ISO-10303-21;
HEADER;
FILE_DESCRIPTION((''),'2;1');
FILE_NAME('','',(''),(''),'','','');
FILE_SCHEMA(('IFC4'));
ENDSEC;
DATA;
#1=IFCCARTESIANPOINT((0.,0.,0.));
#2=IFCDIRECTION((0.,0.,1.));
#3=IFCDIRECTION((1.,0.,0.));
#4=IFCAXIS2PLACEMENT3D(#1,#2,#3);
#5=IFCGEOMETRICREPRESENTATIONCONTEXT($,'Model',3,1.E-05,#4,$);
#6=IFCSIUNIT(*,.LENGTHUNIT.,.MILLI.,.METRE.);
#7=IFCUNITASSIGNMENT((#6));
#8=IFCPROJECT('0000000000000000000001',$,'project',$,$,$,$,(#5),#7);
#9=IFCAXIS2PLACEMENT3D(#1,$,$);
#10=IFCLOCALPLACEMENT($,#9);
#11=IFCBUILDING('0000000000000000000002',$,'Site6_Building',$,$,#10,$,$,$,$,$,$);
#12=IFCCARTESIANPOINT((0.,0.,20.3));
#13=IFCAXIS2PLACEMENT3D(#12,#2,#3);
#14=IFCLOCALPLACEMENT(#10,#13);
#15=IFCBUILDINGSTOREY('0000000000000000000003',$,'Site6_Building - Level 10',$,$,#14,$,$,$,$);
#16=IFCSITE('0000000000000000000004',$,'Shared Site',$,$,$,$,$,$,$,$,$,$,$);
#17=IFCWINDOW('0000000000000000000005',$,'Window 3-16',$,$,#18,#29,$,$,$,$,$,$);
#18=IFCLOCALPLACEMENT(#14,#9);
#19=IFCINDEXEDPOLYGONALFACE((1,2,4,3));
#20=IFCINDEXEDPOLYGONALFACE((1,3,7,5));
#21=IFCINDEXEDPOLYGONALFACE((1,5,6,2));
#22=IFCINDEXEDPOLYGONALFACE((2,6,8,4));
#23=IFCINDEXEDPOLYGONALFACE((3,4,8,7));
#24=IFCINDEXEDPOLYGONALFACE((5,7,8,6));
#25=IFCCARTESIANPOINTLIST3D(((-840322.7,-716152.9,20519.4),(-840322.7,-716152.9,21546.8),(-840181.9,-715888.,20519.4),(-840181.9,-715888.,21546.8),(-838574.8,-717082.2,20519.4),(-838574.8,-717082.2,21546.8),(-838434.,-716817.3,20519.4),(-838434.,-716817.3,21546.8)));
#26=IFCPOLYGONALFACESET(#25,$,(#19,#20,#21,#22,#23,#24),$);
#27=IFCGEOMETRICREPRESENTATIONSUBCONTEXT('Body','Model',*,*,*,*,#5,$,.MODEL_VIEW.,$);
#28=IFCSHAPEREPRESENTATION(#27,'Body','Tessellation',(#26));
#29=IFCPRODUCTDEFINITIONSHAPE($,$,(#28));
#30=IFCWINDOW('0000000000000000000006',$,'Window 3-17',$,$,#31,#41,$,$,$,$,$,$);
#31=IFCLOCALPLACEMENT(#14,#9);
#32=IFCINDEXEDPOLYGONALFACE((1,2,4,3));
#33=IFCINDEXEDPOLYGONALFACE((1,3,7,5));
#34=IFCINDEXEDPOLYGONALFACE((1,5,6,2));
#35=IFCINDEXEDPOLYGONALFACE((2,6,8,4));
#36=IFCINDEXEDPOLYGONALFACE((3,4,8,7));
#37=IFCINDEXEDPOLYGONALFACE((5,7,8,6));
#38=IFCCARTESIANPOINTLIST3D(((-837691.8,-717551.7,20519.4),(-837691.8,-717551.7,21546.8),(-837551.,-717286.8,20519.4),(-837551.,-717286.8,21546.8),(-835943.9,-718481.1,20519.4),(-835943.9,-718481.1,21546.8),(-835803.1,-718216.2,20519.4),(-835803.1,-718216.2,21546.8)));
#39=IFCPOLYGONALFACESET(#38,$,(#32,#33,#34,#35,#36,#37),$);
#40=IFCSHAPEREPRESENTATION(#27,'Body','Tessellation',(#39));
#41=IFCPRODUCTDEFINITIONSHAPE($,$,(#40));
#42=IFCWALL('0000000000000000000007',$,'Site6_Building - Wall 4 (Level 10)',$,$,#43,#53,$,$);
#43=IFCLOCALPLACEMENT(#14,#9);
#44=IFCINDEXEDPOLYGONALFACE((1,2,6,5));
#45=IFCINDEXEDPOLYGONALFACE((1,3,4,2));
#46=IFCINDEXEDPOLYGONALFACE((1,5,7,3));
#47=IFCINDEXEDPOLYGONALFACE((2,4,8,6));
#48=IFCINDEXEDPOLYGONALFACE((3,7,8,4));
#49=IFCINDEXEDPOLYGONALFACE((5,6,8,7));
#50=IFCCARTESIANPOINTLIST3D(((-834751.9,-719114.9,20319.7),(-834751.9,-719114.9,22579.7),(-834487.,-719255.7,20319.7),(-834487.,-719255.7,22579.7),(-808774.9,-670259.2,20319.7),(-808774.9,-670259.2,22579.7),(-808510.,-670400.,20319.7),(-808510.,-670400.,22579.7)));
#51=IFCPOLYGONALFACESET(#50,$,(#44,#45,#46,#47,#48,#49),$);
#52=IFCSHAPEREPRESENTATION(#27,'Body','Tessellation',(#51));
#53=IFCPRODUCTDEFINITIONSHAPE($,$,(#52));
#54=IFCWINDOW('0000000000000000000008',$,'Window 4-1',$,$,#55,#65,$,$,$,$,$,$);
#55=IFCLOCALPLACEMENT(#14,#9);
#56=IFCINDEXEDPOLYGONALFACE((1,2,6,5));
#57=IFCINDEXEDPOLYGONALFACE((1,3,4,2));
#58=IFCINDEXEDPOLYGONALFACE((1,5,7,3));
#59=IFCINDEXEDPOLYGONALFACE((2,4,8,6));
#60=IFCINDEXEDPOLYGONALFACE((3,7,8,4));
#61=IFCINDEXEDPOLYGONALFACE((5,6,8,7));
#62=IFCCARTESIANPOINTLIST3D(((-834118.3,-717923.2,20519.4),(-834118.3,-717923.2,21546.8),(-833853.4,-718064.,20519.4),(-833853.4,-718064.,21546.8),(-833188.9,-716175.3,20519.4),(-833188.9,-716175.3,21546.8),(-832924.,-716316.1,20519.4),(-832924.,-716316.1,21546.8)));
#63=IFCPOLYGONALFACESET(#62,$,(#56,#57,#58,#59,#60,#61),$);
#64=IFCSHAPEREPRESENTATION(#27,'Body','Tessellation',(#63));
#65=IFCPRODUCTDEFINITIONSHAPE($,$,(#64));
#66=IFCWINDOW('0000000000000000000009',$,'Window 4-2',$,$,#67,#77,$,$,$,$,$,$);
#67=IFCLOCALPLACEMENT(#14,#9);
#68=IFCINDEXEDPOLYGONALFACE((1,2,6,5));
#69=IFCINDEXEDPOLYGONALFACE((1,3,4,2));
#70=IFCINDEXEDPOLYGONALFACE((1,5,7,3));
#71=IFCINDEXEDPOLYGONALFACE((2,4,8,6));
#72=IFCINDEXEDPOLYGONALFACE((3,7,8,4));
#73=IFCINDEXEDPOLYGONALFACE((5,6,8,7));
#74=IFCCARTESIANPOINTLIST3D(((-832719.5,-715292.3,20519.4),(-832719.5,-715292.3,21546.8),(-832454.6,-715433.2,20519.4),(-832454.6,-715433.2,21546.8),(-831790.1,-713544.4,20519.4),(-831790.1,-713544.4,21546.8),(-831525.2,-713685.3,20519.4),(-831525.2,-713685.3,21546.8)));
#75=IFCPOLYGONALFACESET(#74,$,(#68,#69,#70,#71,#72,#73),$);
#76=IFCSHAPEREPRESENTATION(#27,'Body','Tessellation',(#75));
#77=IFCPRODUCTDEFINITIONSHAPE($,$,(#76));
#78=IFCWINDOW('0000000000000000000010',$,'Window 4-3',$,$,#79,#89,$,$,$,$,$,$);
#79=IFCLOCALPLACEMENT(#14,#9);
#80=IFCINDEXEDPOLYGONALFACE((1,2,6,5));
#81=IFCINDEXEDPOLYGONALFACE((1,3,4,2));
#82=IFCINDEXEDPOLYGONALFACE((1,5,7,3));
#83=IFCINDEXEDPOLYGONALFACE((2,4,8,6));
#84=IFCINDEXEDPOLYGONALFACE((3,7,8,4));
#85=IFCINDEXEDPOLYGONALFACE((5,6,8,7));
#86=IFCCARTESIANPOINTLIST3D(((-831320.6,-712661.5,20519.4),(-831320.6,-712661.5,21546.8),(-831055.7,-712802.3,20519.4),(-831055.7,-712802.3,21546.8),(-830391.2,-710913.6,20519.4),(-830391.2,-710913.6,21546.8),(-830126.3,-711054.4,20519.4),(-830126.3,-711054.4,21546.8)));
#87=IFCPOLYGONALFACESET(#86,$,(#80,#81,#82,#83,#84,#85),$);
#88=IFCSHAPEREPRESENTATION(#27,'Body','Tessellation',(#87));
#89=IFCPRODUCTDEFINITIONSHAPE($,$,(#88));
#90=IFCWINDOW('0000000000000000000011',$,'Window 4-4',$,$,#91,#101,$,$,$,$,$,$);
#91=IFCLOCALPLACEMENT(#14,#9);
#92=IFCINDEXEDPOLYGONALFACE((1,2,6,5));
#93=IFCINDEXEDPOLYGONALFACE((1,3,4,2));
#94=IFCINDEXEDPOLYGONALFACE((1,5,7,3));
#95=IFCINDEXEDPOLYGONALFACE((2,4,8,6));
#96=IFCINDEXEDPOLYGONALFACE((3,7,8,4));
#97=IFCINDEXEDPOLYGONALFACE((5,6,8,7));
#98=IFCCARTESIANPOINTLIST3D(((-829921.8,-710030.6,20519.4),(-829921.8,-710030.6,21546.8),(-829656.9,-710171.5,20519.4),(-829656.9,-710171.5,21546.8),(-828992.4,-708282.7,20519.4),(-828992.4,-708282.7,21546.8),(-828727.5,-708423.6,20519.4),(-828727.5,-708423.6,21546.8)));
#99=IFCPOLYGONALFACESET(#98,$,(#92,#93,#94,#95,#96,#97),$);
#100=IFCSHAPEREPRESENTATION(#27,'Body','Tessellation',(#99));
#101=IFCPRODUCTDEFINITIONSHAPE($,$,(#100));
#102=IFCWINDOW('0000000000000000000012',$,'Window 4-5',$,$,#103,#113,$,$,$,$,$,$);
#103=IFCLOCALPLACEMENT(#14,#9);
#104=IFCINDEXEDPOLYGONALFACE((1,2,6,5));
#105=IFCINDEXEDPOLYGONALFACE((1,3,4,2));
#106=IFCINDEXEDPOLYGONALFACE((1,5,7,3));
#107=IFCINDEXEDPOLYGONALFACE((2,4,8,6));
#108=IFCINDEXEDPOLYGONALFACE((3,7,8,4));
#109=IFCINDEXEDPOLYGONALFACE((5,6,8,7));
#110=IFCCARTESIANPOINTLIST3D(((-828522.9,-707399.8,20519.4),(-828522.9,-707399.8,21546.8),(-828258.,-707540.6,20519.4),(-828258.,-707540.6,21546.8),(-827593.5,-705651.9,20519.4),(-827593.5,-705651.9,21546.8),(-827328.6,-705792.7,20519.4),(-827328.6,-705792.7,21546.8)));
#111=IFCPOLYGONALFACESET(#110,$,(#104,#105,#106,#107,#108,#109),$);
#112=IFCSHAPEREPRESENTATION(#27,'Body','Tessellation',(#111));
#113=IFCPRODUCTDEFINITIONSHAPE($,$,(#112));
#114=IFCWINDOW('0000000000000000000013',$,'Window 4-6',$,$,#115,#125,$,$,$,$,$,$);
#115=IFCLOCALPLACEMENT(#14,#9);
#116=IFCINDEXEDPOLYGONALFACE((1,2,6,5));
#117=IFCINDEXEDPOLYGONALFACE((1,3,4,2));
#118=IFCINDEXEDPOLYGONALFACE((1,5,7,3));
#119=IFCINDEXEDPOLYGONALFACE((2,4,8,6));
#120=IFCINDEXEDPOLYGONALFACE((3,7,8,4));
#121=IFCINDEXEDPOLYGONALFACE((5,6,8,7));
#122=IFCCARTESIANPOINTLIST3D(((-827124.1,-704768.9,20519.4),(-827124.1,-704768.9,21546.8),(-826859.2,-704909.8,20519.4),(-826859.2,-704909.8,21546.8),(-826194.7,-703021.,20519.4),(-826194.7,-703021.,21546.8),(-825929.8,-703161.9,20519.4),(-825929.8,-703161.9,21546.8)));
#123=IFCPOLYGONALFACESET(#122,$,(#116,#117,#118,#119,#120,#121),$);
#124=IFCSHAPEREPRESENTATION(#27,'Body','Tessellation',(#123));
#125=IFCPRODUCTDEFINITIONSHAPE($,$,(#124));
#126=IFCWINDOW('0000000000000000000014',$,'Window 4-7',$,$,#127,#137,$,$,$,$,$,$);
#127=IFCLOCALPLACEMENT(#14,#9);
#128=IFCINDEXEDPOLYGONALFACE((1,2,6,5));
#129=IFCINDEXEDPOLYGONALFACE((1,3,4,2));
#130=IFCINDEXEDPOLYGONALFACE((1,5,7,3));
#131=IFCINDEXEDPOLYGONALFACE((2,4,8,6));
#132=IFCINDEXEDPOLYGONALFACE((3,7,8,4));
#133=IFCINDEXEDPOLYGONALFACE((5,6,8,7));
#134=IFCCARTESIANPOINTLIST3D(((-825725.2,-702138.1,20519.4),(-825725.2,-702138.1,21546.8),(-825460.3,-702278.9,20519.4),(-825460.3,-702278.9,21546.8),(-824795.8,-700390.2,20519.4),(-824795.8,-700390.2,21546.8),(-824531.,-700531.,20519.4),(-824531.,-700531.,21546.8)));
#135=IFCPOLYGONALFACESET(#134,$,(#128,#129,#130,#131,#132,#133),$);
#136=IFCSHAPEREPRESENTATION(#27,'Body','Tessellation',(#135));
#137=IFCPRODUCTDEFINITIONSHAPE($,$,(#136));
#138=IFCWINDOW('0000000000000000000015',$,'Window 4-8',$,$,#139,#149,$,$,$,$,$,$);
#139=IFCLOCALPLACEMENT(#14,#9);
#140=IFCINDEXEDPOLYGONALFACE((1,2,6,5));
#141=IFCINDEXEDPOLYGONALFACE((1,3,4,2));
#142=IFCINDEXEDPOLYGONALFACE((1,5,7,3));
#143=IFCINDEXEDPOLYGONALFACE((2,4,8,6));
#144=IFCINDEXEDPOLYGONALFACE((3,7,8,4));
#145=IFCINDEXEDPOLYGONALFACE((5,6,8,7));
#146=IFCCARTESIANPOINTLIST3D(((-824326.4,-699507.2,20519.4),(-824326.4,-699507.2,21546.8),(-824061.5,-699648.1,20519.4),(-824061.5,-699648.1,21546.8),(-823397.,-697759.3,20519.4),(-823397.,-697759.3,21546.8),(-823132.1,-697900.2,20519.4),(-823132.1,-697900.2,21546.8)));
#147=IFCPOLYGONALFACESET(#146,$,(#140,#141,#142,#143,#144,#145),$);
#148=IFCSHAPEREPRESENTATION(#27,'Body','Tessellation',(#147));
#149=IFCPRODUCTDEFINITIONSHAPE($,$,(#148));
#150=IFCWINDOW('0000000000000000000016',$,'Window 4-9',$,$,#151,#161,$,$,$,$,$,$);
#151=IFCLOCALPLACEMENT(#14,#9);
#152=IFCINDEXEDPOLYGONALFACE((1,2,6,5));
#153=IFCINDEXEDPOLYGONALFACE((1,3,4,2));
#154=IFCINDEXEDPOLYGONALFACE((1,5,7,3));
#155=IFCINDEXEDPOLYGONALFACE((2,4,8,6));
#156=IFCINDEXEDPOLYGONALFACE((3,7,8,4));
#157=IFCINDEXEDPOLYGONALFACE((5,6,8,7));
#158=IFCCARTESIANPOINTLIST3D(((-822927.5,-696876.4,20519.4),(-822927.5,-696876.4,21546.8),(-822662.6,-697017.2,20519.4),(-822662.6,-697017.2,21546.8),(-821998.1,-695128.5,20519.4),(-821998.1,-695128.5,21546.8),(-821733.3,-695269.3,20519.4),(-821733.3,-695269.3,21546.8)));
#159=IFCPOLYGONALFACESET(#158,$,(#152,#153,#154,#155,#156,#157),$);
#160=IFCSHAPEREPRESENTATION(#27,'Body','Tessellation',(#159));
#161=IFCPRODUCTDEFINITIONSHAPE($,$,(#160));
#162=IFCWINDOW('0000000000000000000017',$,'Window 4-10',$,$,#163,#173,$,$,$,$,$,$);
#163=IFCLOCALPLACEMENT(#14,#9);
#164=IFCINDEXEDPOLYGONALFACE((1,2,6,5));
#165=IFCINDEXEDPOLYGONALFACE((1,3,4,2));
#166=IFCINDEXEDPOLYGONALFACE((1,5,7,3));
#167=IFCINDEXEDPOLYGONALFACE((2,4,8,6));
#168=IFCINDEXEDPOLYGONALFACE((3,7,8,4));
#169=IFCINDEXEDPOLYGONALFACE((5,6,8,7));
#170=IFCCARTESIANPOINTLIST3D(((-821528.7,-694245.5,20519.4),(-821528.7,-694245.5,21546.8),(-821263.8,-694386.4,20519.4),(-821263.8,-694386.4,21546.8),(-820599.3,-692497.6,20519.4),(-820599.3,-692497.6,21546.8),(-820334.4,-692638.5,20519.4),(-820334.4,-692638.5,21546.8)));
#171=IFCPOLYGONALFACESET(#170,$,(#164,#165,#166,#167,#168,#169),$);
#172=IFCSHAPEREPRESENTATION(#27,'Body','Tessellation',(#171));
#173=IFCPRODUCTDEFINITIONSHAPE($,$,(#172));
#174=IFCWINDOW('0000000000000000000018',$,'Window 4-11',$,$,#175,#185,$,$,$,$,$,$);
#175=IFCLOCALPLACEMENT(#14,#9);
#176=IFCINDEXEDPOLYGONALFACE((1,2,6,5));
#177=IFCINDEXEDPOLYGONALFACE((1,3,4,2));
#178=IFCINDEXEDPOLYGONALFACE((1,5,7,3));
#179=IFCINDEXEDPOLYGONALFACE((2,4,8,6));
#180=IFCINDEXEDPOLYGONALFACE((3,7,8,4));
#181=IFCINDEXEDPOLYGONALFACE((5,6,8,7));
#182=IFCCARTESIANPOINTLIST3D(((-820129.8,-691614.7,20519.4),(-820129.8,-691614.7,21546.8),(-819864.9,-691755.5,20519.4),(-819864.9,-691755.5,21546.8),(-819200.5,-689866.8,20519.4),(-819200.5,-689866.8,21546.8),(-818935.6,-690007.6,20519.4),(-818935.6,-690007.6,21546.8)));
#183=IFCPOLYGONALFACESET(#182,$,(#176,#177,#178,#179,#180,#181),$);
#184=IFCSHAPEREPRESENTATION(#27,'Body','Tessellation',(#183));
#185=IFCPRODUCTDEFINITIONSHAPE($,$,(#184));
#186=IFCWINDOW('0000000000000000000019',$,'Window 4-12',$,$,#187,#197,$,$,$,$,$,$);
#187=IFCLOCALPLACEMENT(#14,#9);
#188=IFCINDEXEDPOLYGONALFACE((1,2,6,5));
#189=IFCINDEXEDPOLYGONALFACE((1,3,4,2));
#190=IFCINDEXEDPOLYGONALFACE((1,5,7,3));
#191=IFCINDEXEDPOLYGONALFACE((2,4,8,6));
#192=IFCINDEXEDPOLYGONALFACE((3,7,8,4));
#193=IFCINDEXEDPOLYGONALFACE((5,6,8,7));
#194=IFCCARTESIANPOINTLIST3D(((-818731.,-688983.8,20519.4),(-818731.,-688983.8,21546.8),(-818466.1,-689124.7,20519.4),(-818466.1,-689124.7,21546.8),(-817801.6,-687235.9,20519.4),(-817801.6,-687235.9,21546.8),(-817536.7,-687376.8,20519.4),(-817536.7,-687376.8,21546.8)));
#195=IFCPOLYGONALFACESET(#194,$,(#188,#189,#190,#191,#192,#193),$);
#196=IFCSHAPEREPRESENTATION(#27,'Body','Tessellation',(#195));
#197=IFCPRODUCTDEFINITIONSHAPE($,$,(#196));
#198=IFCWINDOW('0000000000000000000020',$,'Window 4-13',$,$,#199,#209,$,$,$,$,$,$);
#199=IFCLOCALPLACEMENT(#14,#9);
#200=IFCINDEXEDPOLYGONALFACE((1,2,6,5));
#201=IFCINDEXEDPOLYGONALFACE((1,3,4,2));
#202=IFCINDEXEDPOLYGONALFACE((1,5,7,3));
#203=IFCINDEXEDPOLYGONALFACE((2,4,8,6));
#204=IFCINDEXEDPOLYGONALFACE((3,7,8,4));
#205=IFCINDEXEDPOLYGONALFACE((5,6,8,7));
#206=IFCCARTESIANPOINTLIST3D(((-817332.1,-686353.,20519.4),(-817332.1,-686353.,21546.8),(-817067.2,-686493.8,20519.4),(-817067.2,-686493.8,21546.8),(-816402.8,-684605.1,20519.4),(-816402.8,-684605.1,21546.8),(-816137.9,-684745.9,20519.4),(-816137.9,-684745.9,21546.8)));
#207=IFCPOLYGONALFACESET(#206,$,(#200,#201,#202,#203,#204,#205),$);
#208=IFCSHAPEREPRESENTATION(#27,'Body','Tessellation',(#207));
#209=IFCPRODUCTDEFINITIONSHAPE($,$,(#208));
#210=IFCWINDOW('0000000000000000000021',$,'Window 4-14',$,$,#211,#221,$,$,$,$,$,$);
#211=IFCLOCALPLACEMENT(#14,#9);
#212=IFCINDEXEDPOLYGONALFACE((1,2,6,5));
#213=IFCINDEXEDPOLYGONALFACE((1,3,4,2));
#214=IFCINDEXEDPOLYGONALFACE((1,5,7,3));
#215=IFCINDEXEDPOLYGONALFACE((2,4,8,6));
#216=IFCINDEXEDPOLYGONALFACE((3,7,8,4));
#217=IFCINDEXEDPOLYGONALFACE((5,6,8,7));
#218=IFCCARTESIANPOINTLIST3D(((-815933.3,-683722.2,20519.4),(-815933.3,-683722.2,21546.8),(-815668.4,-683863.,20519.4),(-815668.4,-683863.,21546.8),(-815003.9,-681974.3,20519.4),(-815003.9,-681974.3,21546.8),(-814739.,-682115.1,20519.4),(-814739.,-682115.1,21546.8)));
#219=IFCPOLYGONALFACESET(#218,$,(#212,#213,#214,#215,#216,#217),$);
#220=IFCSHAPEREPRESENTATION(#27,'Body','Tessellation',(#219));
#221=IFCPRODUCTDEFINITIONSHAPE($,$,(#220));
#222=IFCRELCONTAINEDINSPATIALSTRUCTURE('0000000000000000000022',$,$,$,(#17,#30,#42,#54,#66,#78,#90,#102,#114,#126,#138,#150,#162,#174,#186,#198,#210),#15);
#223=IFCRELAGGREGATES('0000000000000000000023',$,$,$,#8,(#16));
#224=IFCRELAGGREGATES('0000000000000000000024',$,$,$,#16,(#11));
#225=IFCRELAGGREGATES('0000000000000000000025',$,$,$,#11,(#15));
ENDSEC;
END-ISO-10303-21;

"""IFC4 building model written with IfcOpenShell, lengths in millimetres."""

from ifc_helpers import new_model, si_unit, frame, origin, origin_with_axes, place, context, subcontext, project, spatial, indexed_curve, outline, extrude, element, save


model = new_model("IFC4")

# Units and contexts
model_context = context("Model", 3, precision=1e-05, world=origin_with_axes())
body_context = subcontext(model_context, "Body", "Model", "MODEL_VIEW")
ifc_project = project(units=[si_unit("LENGTHUNIT", "METRE", prefix="MILLI")], contexts=[model_context])

# Site, building, storey
site = spatial("IfcSite", under=ifc_project, Name="Shared Site")
building_placement = place(None, origin())
building = spatial("IfcBuilding", under=site, at=building_placement, Name="Site6_Building")
storey_placement = place(building_placement, frame((0.0, 0.0, 20.3), z_axis=(0.0, 0.0, 1.0), x_axis=(1.0, 0.0, 0.0)))
storey = spatial("IfcBuildingStorey", under=building, at=storey_placement, Name="Site6_Building - Level 10")

# Windows
for number, where, z_axis, x_axis, name in (
    (1, (-840322.7, -716152.9, 20519.4), (0.0, 0.0, 1.0), (0.882948, -0.469472, 0.0), "Window 3-16"),
    (2, (-837691.8, -717551.7, 20519.4), (0.0, 0.0, 1.0), (0.882948, -0.469472, 0.0), "Window 3-17"),
):
    element("IfcWindow", number, at=place(storey_placement, frame(where, z_axis=z_axis, x_axis=x_axis)), inside=storey, Name=name, context=body_context, shape_type="SweptSolid", body=[
        extrude(outline(indexed_curve([(0.0, 0.0), (0.0, 300.0), (1979.6, 300.0), (1979.6, 0.0), (0.0, 0.0)], self_intersect=False)), origin_with_axes(), (0.0, 0.0, 1.0), 1027.5),
    ])

# Wall
wall_1_placement = place(storey_placement, frame((-834487.0, -719255.7, 20319.7), z_axis=(0.0, 0.0, 1.0), x_axis=(0.469472, 0.882948, 0.0)))
element("IfcWall", 3, at=wall_1_placement, inside=storey, Name="Site6_Building - Wall 4 (Level 10)", context=body_context, shape_type="SweptSolid", body=[
    extrude(outline(indexed_curve([(0.0, 0.0), (0.0, 300.0), (55332.5, 300.0), (55332.5, 0.0), (0.0, 0.0)], self_intersect=False)), origin_with_axes(), (0.0, 0.0, 1.0), 2260.0),
])

# Windows
for number, where, z_axis, x_axis, name in (
    (4, (-833853.4, -718064.0, 20519.4), (0.0, 0.0, 1.0), (0.469472, 0.882948, 0.0), "Window 4-1"),
    (5, (-832454.6, -715433.2, 20519.4), (0.0, 0.0, 1.0), (0.469472, 0.882948, 0.0), "Window 4-2"),
    (6, (-831055.7, -712802.3, 20519.4), (0.0, 0.0, 1.0), (0.469472, 0.882948, 0.0), "Window 4-3"),
    (7, (-829656.9, -710171.5, 20519.4), (0.0, 0.0, 1.0), (0.469472, 0.882948, 0.0), "Window 4-4"),
    (8, (-828258.0, -707540.6, 20519.4), (0.0, 0.0, 1.0), (0.469472, 0.882948, 0.0), "Window 4-5"),
    (9, (-826859.2, -704909.8, 20519.4), (0.0, 0.0, 1.0), (0.469472, 0.882948, 0.0), "Window 4-6"),
    (10, (-825460.3, -702278.9, 20519.4), (0.0, 0.0, 1.0), (0.469472, 0.882948, 0.0), "Window 4-7"),
    (11, (-824061.5, -699648.1, 20519.4), (0.0, 0.0, 1.0), (0.469472, 0.882948, 0.0), "Window 4-8"),
    (12, (-822662.6, -697017.2, 20519.4), (0.0, 0.0, 1.0), (0.469472, 0.882948, 0.0), "Window 4-9"),
    (13, (-821263.8, -694386.4, 20519.4), (0.0, 0.0, 1.0), (0.469472, 0.882948, 0.0), "Window 4-10"),
    (14, (-819864.9, -691755.5, 20519.4), (0.0, 0.0, 1.0), (0.469472, 0.882948, 0.0), "Window 4-11"),
    (15, (-818466.1, -689124.7, 20519.4), (0.0, 0.0, 1.0), (0.469472, 0.882948, 0.0), "Window 4-12"),
    (16, (-817067.2, -686493.8, 20519.4), (0.0, 0.0, 1.0), (0.469472, 0.882948, 0.0), "Window 4-13"),
    (17, (-815668.4, -683863.0, 20519.4), (0.0, 0.0, 1.0), (0.469472, 0.882948, 0.0), "Window 4-14"),
):
    element("IfcWindow", number, at=place(storey_placement, frame(where, z_axis=z_axis, x_axis=x_axis)), inside=storey, Name=name, context=body_context, shape_type="SweptSolid", body=[
        extrude(outline(indexed_curve([(0.0, 0.0), (0.0, 300.0), (1979.6, 300.0), (1979.6, 0.0), (0.0, 0.0)], self_intersect=False)), origin_with_axes(), (0.0, 0.0, 1.0), 1027.5),
    ])

save(model, "model.ifc")
